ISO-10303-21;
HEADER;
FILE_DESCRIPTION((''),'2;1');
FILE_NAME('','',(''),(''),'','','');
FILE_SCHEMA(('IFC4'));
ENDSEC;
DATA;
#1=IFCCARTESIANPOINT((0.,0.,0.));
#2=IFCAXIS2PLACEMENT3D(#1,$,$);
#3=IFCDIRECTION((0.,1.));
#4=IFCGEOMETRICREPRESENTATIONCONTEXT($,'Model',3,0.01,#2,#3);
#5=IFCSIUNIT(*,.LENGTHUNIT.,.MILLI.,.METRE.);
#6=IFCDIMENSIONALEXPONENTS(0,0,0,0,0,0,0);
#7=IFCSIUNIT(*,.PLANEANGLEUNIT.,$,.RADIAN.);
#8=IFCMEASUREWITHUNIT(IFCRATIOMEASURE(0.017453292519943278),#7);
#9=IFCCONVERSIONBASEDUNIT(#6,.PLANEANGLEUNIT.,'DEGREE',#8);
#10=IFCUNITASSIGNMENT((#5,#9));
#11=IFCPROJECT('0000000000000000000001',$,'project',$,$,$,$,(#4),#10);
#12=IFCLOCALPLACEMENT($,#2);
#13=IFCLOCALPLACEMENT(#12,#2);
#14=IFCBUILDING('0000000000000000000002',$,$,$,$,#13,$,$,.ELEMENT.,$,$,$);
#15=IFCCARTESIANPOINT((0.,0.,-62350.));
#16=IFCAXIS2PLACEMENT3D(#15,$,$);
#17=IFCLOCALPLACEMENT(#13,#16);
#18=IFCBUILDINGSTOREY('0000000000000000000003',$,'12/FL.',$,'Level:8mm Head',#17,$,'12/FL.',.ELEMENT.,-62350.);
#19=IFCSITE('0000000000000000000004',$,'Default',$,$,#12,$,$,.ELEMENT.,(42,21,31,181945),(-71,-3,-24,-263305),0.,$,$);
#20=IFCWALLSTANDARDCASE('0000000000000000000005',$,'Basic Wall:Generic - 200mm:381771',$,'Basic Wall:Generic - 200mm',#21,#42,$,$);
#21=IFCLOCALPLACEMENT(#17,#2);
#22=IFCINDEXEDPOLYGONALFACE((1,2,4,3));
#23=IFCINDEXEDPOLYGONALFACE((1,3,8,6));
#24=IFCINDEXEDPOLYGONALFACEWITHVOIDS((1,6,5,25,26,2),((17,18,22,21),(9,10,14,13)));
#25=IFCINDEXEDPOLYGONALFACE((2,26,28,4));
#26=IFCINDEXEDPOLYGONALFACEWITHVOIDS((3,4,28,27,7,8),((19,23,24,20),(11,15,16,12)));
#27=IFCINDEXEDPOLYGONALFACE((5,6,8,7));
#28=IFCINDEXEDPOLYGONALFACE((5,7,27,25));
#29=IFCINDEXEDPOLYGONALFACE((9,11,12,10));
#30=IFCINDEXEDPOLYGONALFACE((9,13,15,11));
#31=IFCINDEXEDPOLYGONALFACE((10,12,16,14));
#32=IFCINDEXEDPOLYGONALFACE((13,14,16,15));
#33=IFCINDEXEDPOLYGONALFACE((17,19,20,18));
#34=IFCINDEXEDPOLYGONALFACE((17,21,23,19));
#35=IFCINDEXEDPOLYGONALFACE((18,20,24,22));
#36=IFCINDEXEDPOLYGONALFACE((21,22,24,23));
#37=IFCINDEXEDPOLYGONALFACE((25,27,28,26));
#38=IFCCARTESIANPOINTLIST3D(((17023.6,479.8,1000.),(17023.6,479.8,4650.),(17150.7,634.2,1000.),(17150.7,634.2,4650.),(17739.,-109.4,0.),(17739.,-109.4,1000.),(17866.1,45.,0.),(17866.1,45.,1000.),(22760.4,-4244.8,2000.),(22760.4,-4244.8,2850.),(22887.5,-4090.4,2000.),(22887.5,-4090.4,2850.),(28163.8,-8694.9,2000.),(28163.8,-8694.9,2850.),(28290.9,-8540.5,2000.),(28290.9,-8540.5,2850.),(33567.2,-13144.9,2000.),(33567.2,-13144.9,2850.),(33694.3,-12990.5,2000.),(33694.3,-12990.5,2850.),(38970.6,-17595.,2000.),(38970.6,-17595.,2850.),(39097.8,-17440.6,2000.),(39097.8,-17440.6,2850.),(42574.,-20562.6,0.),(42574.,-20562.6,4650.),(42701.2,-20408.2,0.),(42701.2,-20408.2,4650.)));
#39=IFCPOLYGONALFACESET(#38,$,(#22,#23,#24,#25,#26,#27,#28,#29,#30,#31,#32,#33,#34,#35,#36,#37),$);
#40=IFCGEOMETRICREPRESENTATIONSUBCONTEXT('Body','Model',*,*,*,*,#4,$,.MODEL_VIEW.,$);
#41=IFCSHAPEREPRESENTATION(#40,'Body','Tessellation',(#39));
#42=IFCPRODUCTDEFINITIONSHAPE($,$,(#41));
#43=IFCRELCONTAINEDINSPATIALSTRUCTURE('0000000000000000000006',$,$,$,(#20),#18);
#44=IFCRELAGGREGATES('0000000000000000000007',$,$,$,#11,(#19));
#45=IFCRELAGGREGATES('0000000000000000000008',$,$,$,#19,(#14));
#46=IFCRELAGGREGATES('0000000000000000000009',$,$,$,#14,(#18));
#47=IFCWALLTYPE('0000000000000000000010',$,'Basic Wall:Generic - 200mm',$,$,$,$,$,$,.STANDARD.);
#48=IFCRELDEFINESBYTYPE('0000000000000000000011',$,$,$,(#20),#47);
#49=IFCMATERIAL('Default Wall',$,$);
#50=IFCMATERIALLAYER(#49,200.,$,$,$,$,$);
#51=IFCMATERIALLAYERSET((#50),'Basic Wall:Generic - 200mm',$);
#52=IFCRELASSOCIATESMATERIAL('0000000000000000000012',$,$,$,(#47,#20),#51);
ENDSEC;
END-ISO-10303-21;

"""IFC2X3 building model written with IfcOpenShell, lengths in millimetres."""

from ifc_helpers import new_model, entity, si_unit, converted_unit, direction, frame, frame_2d, origin, place, context, subcontext, project, spatial, rectangle, extrude, material, layer, layer_set, layer_usage, type_object, element, save


model = new_model("IFC2X3")

# Units and contexts
model_context = context("Model", 3, precision=0.01, world=origin(), true_north=direction((0.0, 1.0)))
body_context = subcontext(model_context, "Body", "Model", "MODEL_VIEW")
ifc_project = project(units=[si_unit("LENGTHUNIT", "METRE", prefix="MILLI"), converted_unit("PLANEANGLEUNIT", "DEGREE", entity("IfcRatioMeasure", 0.017453292519943278), si_unit("PLANEANGLEUNIT", "RADIAN"), dimensions=[0, 0, 0, 0, 0, 0, 0])], contexts=[model_context])

# Site, building, storey
site_placement = place(None, origin())
site = spatial("IfcSite", under=ifc_project, at=site_placement, Name="Default", CompositionType="ELEMENT", RefLatitude=(42, 21, 31, 181945), RefLongitude=(-71, -3, -24, -263305), RefElevation=0.0)
building_placement = place(site_placement, origin())
building = spatial("IfcBuilding", under=site, at=building_placement, CompositionType="ELEMENT")
storey_placement = place(building_placement, frame((0.0, 0.0, -62350.0)))
storey = spatial("IfcBuildingStorey", under=building, at=storey_placement, Name="12/FL.", ObjectType="Level:8mm Head", LongName="12/FL.", CompositionType="ELEMENT", Elevation=-62350.0)

# Wall, openings
ifc_material_1 = material(Name="Default Wall")
ifc_layer = layer(ifc_material_1, 200.0)
ifc_layer_set = layer_set([ifc_layer], Name="Basic Wall:Generic - 200mm")
ifc_layer_usage = layer_usage(ifc_layer_set, "AXIS2", "NEGATIVE", 100.0)
wall_type = type_object("IfcWallType", Name="Basic Wall:Generic - 200mm", PredefinedType="STANDARD", material=ifc_layer_set)
wall_1_placement = place(storey_placement, frame((42637.6, -20485.4, 0.0), z_axis=(0.0, 0.0, 1.0), x_axis=(-0.771917, 0.635723, 0.0)))
wall_1 = element("IfcWallStandardCase", 1, at=wall_1_placement, inside=storey, type_object=wall_type, material=ifc_layer_usage, Name="Basic Wall:Generic - 200mm:381771", ObjectType="Basic Wall:Generic - 200mm", context=body_context, shape_type="SweptSolid", body=[
    extrude(rectangle(XDim=33100.0, YDim=200.0, at=frame_2d((16550.0, 0.0), x_axis=(-1.0, 0.0))), origin(), (0.0, 0.0, 1.0), 4650.0),
])
opening_1_placement = place(wall_1_placement, origin())
element("IfcOpeningElement", 2, at=opening_1_placement, cuts=wall_1, ObjectType="Opening", context=body_context, shape_type="SweptSolid", body=[
    extrude(rectangle(XDim=850.0, YDim=7000.0, at=frame_2d((0.0, 0.0), x_axis=(1.0, 0.0))), frame((8168.1, -100.0, 2425.0), z_axis=(0.0, 1.0, 0.0), x_axis=(0.0, 0.0, -1.0)), (0.0, 0.0, 1.0), 200.0),
])
opening_2_placement = place(wall_1_placement, origin())
element("IfcOpeningElement", 3, at=opening_2_placement, cuts=wall_1, ObjectType="Opening", context=body_context, shape_type="SweptSolid", body=[
    extrude(rectangle(XDim=850.0, YDim=7000.0, at=frame_2d((0.0, 0.0), x_axis=(1.0, 0.0))), frame((22168.1, -100.0, 2425.0), z_axis=(0.0, 1.0, 0.0), x_axis=(0.0, 0.0, -1.0)), (0.0, 0.0, 1.0), 200.0),
])
opening_3_placement = place(wall_1_placement, frame((45935.8, 11292.7, 0.0), z_axis=(0.0, 0.0, 1.0), x_axis=(-0.771917, -0.635723, 0.0)))
element("IfcOpeningElement", 4, at=opening_3_placement, cuts=wall_1, ObjectType="Opening", context=body_context, shape_type="SweptSolid", body=[
    extrude(rectangle(XDim=1000.0, YDim=1010.1, at=frame_2d((0.0, 0.0), x_axis=(1.0, 0.0))), frame((17484.3, 375.9, 500.0), z_axis=(-0.635723, -0.771917, 0.0), x_axis=(0.0, 0.0, -1.0)), (0.0, 0.0, 1.0), 1012.7),
])

save(model, "model.ifc")
